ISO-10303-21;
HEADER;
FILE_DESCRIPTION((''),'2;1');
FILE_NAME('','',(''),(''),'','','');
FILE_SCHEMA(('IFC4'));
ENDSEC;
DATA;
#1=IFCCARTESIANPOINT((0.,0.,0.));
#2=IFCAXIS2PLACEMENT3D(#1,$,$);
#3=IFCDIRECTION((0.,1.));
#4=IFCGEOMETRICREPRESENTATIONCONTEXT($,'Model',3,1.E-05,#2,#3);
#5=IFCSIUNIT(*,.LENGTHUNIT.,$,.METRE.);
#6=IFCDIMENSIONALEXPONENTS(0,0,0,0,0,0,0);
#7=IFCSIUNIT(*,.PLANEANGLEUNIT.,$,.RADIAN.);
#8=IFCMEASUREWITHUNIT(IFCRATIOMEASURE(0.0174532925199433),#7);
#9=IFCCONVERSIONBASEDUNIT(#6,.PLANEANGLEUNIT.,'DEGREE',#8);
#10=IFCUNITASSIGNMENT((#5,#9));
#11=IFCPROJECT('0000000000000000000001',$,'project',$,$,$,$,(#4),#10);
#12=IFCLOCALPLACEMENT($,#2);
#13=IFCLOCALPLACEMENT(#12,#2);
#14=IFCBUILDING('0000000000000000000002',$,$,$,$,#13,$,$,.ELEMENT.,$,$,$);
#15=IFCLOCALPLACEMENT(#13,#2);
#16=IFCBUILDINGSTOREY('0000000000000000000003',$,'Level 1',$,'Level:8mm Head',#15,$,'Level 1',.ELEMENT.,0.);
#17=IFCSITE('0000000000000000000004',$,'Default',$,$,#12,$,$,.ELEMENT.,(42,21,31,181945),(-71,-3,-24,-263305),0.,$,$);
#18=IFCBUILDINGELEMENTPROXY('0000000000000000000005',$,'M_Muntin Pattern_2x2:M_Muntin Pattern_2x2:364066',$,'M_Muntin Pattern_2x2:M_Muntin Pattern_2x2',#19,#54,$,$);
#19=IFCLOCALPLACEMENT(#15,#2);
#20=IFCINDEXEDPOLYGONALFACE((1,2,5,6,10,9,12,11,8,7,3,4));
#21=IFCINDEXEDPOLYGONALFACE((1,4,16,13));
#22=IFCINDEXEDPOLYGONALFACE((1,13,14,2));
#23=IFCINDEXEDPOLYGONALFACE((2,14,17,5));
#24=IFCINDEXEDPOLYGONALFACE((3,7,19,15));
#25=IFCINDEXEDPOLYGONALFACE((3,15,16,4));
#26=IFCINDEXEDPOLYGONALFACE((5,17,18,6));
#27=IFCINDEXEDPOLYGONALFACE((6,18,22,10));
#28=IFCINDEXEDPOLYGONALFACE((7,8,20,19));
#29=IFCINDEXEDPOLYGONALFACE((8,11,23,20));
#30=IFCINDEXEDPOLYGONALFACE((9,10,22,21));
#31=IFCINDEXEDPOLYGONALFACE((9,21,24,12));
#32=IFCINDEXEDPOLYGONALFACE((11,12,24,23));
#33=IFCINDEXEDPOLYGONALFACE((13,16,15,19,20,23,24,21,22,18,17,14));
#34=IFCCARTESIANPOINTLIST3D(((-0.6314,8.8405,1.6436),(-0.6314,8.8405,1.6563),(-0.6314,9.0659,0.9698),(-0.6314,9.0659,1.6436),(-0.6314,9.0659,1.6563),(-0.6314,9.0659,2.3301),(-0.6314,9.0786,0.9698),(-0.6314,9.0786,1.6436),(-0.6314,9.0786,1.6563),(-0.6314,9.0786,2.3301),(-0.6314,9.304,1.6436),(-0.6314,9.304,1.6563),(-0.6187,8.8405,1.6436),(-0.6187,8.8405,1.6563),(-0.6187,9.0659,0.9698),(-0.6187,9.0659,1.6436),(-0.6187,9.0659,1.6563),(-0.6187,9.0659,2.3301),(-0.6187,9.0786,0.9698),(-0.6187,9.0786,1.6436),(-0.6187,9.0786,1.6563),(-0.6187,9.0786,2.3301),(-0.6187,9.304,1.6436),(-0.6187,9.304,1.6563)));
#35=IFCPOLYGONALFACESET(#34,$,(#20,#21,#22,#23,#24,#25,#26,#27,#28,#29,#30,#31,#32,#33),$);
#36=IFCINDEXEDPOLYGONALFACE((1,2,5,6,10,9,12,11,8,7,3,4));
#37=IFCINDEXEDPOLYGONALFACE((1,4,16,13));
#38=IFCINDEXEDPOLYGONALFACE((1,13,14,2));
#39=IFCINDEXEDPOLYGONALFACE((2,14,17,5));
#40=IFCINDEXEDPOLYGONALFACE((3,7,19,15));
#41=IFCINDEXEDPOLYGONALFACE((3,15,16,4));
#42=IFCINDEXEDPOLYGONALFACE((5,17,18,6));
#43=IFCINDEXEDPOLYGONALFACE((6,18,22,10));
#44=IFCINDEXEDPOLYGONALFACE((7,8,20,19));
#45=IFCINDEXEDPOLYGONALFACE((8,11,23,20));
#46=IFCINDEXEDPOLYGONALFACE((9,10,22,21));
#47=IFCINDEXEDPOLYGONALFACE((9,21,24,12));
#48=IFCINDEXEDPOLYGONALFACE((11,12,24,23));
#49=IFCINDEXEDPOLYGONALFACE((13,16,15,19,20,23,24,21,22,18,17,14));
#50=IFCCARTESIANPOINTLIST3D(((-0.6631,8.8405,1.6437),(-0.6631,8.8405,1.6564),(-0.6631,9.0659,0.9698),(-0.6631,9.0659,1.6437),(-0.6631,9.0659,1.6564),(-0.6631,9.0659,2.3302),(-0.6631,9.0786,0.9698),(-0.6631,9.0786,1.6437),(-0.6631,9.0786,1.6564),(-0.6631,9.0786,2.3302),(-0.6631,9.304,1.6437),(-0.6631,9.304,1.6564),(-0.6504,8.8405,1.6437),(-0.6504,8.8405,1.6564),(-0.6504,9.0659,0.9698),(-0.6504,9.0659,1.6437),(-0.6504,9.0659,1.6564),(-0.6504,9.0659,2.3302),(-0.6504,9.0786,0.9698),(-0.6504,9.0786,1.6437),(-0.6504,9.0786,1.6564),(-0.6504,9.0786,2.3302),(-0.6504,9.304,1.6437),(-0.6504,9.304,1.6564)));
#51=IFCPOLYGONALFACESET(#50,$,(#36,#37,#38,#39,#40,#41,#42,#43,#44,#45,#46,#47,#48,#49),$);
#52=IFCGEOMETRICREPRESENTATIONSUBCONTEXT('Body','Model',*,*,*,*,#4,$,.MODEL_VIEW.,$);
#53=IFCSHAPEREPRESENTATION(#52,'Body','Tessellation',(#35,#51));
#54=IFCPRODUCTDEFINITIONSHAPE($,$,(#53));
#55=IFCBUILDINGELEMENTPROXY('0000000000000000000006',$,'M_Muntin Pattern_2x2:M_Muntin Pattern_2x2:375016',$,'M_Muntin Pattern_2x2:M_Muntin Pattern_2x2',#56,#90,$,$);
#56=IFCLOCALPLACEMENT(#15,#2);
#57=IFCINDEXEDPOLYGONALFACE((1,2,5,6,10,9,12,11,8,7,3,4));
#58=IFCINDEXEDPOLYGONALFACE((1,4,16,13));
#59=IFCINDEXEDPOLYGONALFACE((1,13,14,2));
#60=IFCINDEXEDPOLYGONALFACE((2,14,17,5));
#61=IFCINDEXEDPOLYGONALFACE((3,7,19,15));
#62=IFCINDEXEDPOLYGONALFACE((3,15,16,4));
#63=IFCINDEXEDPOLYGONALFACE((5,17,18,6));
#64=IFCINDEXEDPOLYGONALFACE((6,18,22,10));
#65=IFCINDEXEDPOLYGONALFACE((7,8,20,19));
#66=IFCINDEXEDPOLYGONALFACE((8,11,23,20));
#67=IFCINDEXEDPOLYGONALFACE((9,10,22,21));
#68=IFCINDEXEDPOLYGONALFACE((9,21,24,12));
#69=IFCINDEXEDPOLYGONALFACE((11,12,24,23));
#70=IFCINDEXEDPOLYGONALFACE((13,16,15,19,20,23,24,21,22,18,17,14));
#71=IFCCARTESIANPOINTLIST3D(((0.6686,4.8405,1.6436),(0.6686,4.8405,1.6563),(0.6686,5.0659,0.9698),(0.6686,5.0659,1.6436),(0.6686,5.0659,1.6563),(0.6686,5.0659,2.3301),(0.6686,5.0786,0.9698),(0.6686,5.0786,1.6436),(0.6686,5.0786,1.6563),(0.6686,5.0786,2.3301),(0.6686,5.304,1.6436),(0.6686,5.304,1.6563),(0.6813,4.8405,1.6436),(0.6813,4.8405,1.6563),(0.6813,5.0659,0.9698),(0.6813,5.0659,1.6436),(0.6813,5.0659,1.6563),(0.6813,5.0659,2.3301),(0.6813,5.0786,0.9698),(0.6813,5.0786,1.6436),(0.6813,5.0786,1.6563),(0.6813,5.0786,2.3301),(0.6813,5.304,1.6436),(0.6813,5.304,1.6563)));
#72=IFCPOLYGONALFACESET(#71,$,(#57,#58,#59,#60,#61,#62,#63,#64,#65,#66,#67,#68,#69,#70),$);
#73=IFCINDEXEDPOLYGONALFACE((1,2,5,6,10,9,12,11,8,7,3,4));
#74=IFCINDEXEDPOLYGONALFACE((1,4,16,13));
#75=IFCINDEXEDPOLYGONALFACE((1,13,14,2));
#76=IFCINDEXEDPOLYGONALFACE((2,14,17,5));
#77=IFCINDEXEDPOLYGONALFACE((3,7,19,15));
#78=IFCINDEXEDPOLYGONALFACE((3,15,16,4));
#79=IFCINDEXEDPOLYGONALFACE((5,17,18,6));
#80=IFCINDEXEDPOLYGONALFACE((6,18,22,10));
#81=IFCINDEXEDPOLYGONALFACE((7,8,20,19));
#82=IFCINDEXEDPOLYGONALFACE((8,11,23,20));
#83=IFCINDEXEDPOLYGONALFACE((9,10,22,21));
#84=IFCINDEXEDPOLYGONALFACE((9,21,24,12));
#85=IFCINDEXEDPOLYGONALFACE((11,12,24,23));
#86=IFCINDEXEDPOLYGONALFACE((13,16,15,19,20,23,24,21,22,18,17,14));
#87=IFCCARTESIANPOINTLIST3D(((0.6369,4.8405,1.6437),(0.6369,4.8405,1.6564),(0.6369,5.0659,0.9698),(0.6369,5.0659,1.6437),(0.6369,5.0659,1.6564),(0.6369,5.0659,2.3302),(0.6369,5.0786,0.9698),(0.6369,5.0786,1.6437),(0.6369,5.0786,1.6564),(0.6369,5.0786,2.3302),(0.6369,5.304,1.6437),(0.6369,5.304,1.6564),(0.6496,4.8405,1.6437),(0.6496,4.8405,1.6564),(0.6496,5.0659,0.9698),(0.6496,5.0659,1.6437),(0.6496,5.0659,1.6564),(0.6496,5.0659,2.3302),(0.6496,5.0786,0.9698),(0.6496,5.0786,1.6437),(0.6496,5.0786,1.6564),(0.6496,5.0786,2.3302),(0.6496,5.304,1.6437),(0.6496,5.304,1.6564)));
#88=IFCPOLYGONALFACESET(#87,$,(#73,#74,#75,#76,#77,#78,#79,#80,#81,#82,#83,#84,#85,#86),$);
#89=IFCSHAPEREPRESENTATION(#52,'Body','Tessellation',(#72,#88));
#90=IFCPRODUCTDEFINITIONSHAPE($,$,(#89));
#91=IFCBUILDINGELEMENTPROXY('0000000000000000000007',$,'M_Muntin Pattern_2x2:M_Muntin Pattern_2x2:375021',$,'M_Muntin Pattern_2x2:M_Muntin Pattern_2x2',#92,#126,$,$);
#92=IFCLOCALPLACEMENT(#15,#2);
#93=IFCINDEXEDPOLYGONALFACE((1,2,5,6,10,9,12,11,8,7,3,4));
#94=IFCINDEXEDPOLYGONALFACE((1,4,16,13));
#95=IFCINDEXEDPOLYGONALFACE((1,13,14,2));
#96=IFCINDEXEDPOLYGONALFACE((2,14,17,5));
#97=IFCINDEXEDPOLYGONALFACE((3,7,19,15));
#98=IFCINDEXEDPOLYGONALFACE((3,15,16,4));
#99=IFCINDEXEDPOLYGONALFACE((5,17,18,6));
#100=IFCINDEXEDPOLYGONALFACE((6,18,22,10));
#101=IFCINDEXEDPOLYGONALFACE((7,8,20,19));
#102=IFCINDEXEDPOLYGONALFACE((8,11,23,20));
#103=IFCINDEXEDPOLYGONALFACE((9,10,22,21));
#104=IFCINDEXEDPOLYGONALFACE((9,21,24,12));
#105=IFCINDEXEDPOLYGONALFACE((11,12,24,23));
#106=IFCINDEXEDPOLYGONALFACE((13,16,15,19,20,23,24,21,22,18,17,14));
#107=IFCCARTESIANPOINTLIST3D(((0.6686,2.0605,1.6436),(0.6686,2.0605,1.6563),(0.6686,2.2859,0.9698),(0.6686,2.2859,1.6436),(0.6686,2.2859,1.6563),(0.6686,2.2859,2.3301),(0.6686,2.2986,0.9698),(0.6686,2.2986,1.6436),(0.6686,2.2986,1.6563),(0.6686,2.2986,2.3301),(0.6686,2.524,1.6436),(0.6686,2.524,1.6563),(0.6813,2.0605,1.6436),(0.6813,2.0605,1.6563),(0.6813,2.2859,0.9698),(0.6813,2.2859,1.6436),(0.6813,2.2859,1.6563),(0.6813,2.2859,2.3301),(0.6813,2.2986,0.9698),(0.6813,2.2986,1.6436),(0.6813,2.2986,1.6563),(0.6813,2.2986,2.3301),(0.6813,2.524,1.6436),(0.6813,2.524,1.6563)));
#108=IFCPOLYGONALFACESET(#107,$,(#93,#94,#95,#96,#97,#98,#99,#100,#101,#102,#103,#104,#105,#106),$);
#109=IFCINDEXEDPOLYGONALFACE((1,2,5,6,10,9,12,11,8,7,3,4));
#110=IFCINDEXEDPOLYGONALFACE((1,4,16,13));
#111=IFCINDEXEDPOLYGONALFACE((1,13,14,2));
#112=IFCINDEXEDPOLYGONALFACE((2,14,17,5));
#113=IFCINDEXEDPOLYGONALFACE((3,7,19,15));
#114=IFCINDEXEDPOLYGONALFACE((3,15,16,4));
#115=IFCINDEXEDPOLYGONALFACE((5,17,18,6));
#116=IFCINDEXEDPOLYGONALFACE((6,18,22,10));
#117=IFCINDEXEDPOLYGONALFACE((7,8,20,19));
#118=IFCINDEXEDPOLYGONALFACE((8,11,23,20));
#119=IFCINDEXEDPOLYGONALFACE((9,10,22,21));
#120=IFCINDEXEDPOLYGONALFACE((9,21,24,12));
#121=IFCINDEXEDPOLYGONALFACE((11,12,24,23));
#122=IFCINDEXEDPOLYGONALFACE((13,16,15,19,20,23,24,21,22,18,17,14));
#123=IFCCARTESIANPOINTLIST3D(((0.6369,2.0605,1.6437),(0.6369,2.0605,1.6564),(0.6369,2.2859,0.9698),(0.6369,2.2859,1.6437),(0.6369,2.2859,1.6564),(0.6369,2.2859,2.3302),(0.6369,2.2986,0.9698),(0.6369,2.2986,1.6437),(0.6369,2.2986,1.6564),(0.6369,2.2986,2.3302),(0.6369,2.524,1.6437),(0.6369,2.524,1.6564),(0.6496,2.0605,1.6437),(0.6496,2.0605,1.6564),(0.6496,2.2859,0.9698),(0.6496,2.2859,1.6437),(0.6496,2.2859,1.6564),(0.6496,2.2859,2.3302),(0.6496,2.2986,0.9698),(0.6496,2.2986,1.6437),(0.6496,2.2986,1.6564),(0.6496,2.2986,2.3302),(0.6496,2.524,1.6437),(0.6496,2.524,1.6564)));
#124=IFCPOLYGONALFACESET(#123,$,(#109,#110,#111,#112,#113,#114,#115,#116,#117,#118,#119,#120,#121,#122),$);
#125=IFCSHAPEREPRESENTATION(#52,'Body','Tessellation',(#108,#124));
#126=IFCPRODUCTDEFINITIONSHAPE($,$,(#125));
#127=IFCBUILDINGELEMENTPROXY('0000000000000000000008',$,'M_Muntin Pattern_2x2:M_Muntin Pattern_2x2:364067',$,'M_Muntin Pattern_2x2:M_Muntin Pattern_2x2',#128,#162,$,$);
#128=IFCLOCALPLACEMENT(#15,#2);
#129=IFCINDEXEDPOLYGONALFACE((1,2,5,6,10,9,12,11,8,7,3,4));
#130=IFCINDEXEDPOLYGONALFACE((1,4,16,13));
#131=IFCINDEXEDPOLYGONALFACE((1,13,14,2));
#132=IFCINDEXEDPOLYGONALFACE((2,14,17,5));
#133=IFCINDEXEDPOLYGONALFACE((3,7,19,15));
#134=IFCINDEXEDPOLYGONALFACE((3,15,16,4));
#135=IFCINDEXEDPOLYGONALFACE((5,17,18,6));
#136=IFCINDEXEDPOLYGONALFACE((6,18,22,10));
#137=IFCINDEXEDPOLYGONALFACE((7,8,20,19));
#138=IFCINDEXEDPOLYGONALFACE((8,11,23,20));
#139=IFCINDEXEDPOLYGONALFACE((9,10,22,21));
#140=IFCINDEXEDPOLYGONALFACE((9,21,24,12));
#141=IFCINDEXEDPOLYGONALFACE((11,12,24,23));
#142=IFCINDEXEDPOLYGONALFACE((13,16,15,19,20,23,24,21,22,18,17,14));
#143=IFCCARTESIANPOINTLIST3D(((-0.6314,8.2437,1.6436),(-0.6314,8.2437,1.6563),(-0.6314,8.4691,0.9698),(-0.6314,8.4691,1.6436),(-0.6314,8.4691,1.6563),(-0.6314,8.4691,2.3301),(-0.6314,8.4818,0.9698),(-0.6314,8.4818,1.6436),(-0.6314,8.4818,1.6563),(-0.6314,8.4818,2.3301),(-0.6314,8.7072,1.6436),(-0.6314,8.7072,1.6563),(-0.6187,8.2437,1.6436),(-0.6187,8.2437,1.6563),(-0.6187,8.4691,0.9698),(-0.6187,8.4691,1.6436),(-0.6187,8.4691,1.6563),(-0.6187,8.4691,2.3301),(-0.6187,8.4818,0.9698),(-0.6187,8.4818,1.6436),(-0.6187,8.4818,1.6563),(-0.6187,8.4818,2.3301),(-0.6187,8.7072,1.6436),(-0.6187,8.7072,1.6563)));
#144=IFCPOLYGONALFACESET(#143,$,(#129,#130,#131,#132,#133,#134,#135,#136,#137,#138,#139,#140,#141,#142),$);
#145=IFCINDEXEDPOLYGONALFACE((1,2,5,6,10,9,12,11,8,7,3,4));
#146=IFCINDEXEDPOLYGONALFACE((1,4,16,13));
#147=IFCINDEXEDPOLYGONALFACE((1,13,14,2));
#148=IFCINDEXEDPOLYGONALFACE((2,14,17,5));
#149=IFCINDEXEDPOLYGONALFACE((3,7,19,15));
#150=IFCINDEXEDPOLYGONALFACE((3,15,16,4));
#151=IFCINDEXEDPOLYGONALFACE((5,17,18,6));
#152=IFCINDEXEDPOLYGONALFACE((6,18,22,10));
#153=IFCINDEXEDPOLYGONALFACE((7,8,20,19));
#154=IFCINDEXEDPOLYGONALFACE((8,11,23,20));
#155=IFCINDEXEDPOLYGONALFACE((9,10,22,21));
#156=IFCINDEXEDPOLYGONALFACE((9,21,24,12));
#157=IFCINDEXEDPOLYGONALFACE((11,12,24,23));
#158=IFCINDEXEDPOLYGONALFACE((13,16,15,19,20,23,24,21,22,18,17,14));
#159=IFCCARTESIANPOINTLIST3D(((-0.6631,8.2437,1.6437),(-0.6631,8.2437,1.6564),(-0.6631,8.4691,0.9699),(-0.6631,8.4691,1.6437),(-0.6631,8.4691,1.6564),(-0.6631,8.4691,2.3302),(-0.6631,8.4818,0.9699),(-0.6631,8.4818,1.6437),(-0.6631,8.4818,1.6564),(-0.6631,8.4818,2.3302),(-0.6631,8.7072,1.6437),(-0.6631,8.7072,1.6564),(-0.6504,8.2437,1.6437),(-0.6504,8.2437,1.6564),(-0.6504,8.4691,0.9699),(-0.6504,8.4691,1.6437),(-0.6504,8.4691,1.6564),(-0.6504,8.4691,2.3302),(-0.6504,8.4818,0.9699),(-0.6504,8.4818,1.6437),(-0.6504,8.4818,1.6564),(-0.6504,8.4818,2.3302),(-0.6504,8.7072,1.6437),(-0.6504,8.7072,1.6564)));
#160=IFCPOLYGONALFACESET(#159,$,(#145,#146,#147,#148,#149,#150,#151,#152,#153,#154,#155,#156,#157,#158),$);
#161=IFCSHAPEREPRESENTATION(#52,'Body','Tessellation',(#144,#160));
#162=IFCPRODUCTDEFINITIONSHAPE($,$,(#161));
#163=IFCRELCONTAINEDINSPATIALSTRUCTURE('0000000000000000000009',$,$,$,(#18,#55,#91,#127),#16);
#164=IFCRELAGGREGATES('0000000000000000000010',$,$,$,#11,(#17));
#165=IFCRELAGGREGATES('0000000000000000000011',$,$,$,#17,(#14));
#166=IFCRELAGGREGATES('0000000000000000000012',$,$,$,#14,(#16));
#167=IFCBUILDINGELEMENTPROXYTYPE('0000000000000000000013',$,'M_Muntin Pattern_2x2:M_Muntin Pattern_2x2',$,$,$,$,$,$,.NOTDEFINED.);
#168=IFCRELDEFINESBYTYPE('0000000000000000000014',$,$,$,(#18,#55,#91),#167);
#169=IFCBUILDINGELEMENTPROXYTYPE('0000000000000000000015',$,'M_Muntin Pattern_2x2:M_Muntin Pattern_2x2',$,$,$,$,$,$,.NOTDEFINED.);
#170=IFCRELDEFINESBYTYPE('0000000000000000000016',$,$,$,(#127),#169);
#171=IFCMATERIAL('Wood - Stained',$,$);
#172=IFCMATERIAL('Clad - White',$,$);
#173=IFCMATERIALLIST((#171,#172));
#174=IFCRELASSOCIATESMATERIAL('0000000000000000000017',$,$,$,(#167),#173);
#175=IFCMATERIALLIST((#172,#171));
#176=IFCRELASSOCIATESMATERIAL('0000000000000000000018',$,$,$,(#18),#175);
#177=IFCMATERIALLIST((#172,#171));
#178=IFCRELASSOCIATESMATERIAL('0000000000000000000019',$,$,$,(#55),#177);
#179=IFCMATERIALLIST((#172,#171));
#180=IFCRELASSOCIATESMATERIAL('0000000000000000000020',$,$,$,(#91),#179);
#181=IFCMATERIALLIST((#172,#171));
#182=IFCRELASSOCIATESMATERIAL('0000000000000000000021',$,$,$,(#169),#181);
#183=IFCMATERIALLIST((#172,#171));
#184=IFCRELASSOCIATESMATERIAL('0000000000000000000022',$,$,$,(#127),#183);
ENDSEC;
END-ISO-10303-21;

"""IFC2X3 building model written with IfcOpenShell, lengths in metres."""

from ifc_helpers import new_model, entity, si_unit, converted_unit, direction, frame, origin, place, context, subcontext, project, spatial, polyline, outline, extrude, source, transform, mapped, material, material_list, type_object, type_shapes, element, save


model = new_model("IFC2X3")

# Units and contexts
model_context = context("Model", 3, precision=1e-05, world=origin(), true_north=direction((0.0, 1.0)))
body_context = subcontext(model_context, "Body", "Model", "MODEL_VIEW")
ifc_project = project(units=[si_unit("LENGTHUNIT", "METRE"), converted_unit("PLANEANGLEUNIT", "DEGREE", entity("IfcRatioMeasure", 0.0174532925199433), si_unit("PLANEANGLEUNIT", "RADIAN"), dimensions=[0, 0, 0, 0, 0, 0, 0])], contexts=[model_context])

# Site, building, storey
site_placement = place(None, origin())
site = spatial("IfcSite", under=ifc_project, at=site_placement, Name="Default", CompositionType="ELEMENT", RefLatitude=(42, 21, 31, 181945), RefLongitude=(-71, -3, -24, -263305), RefElevation=0.0)
building_placement = place(site_placement, origin())
building = spatial("IfcBuilding", under=site, at=building_placement, CompositionType="ELEMENT")
storey_placement = place(building_placement, origin())
storey = spatial("IfcBuildingStorey", under=building, at=storey_placement, Name="Level 1", ObjectType="Level:8mm Head", LongName="Level 1", CompositionType="ELEMENT", Elevation=0.0)

# Building element proxies
ifc_material_1 = material(Name="Clad - White")
ifc_material_2 = material(Name="Wood - Stained")
ifc_material_list_1 = material_list([ifc_material_1, ifc_material_2])
ifc_material_list_2 = material_list([ifc_material_2, ifc_material_1])
building_element_proxy_type_1 = type_object("IfcBuildingElementProxyType", Name="M_Muntin Pattern_2x2:M_Muntin Pattern_2x2", PredefinedType="NOTDEFINED", material=ifc_material_list_2)
shared_shape_1 = source(origin(), body_context, "Body", "SweptSolid", [
    extrude(outline(polyline([(0.0064, -0.0064), (0.6801, -0.0064), (0.6801, 0.0063), (0.0064, 0.0063), (0.0064, 0.2317), (-0.0063, 0.2317), (-0.0063, 0.0063), (-0.6802, 0.0063), (-0.6802, -0.0064), (-0.0063, -0.0064), (-0.0063, -0.2317), (0.0064, -0.2317), (0.0064, -0.0064)])), frame((0.0, 0.0095, 0.6801), z_axis=(0.0, 1.0, 0.0), x_axis=(0.0, 0.0, 1.0)), (0.0, 0.0, 1.0), 0.0127),
    extrude(outline(polyline([(0.0064, -0.0064), (0.6802, -0.0064), (0.6802, 0.0063), (0.0064, 0.0063), (0.0064, 0.2317), (-0.0063, 0.2317), (-0.0063, 0.0063), (-0.6802, 0.0063), (-0.6802, -0.0064), (-0.0063, -0.0064), (-0.0063, -0.2317), (0.0064, -0.2317), (0.0064, -0.0064)])), frame((0.0, -0.0222, 0.6802), z_axis=(0.0, 1.0, 0.0), x_axis=(0.0, 0.0, 1.0)), (0.0, 0.0, 1.0), 0.0127),
])
type_shapes(building_element_proxy_type_1, [shared_shape_1])
proxy_1_placement = place(storey_placement, frame((-0.6409, 9.0723, 0.9698), z_axis=(0.0, 0.0, 1.0), x_axis=(0.0, -1.0, 0.0)))
element("IfcBuildingElementProxy", 1, at=proxy_1_placement, inside=storey, type_object=building_element_proxy_type_1, material=ifc_material_list_1, Name="M_Muntin Pattern_2x2:M_Muntin Pattern_2x2:364066", ObjectType="M_Muntin Pattern_2x2:M_Muntin Pattern_2x2", context=body_context, shape_type="MappedRepresentation", body=[
    mapped(shared_shape_1, transform((0.0, 0.0, 0.0), scale=1.0)),
])
ifc_material_list_3 = material_list([ifc_material_1, ifc_material_2])
proxy_2_placement = place(storey_placement, frame((0.6591, 5.0723, 0.9698), z_axis=(0.0, 0.0, 1.0), x_axis=(0.0, -1.0, 0.0)))
element("IfcBuildingElementProxy", 2, at=proxy_2_placement, inside=storey, type_object=building_element_proxy_type_1, material=ifc_material_list_3, Name="M_Muntin Pattern_2x2:M_Muntin Pattern_2x2:375016", ObjectType="M_Muntin Pattern_2x2:M_Muntin Pattern_2x2", context=body_context, shape_type="MappedRepresentation", body=[
    mapped(shared_shape_1, transform((0.0, 0.0, 0.0), scale=1.0)),
])
ifc_material_list_4 = material_list([ifc_material_1, ifc_material_2])
proxy_3_placement = place(storey_placement, frame((0.6591, 2.2923, 0.9698), z_axis=(0.0, 0.0, 1.0), x_axis=(0.0, -1.0, 0.0)))
element("IfcBuildingElementProxy", 3, at=proxy_3_placement, inside=storey, type_object=building_element_proxy_type_1, material=ifc_material_list_4, Name="M_Muntin Pattern_2x2:M_Muntin Pattern_2x2:375021", ObjectType="M_Muntin Pattern_2x2:M_Muntin Pattern_2x2", context=body_context, shape_type="MappedRepresentation", body=[
    mapped(shared_shape_1, transform((0.0, 0.0, 0.0), scale=1.0)),
])
ifc_material_list_5 = material_list([ifc_material_1, ifc_material_2])
ifc_material_list_6 = material_list([ifc_material_1, ifc_material_2])
building_element_proxy_type_2 = type_object("IfcBuildingElementProxyType", Name="M_Muntin Pattern_2x2:M_Muntin Pattern_2x2", PredefinedType="NOTDEFINED", material=ifc_material_list_6)
shared_shape_2 = source(origin(), body_context, "Body", "SweptSolid", [
    extrude(outline(polyline([(0.0064, -0.0064), (0.6801, -0.0064), (0.6801, 0.0063), (0.0064, 0.0063), (0.0064, 0.2317), (-0.0063, 0.2317), (-0.0063, 0.0063), (-0.6802, 0.0063), (-0.6802, -0.0064), (-0.0063, -0.0064), (-0.0063, -0.2317), (0.0064, -0.2317), (0.0064, -0.0064)])), frame((0.0, -0.0222, 0.6801), z_axis=(0.0, 1.0, 0.0), x_axis=(0.0, 0.0, 1.0)), (0.0, 0.0, 1.0), 0.0127),
    extrude(outline(polyline([(0.0064, -0.0064), (0.6802, -0.0064), (0.6802, 0.0063), (0.0064, 0.0063), (0.0064, 0.2317), (-0.0063, 0.2317), (-0.0063, 0.0063), (-0.6802, 0.0063), (-0.6802, -0.0064), (-0.0063, -0.0064), (-0.0063, -0.2317), (0.0064, -0.2317), (0.0064, -0.0064)])), frame((0.0, 0.0095, 0.6802), z_axis=(0.0, 1.0, 0.0), x_axis=(0.0, 0.0, 1.0)), (0.0, 0.0, 1.0), 0.0127),
])
type_shapes(building_element_proxy_type_2, [shared_shape_2])
proxy_4_placement = place(storey_placement, frame((-0.6409, 8.4754, 0.9699), z_axis=(0.0, 0.0, 1.0), x_axis=(0.0, 1.0, 0.0)))
element("IfcBuildingElementProxy", 4, at=proxy_4_placement, inside=storey, type_object=building_element_proxy_type_2, material=ifc_material_list_5, Name="M_Muntin Pattern_2x2:M_Muntin Pattern_2x2:364067", ObjectType="M_Muntin Pattern_2x2:M_Muntin Pattern_2x2", context=body_context, shape_type="MappedRepresentation", body=[
    mapped(shared_shape_2, transform((0.0, 0.0, 0.0), scale=1.0)),
])

save(model, "model.ifc")
